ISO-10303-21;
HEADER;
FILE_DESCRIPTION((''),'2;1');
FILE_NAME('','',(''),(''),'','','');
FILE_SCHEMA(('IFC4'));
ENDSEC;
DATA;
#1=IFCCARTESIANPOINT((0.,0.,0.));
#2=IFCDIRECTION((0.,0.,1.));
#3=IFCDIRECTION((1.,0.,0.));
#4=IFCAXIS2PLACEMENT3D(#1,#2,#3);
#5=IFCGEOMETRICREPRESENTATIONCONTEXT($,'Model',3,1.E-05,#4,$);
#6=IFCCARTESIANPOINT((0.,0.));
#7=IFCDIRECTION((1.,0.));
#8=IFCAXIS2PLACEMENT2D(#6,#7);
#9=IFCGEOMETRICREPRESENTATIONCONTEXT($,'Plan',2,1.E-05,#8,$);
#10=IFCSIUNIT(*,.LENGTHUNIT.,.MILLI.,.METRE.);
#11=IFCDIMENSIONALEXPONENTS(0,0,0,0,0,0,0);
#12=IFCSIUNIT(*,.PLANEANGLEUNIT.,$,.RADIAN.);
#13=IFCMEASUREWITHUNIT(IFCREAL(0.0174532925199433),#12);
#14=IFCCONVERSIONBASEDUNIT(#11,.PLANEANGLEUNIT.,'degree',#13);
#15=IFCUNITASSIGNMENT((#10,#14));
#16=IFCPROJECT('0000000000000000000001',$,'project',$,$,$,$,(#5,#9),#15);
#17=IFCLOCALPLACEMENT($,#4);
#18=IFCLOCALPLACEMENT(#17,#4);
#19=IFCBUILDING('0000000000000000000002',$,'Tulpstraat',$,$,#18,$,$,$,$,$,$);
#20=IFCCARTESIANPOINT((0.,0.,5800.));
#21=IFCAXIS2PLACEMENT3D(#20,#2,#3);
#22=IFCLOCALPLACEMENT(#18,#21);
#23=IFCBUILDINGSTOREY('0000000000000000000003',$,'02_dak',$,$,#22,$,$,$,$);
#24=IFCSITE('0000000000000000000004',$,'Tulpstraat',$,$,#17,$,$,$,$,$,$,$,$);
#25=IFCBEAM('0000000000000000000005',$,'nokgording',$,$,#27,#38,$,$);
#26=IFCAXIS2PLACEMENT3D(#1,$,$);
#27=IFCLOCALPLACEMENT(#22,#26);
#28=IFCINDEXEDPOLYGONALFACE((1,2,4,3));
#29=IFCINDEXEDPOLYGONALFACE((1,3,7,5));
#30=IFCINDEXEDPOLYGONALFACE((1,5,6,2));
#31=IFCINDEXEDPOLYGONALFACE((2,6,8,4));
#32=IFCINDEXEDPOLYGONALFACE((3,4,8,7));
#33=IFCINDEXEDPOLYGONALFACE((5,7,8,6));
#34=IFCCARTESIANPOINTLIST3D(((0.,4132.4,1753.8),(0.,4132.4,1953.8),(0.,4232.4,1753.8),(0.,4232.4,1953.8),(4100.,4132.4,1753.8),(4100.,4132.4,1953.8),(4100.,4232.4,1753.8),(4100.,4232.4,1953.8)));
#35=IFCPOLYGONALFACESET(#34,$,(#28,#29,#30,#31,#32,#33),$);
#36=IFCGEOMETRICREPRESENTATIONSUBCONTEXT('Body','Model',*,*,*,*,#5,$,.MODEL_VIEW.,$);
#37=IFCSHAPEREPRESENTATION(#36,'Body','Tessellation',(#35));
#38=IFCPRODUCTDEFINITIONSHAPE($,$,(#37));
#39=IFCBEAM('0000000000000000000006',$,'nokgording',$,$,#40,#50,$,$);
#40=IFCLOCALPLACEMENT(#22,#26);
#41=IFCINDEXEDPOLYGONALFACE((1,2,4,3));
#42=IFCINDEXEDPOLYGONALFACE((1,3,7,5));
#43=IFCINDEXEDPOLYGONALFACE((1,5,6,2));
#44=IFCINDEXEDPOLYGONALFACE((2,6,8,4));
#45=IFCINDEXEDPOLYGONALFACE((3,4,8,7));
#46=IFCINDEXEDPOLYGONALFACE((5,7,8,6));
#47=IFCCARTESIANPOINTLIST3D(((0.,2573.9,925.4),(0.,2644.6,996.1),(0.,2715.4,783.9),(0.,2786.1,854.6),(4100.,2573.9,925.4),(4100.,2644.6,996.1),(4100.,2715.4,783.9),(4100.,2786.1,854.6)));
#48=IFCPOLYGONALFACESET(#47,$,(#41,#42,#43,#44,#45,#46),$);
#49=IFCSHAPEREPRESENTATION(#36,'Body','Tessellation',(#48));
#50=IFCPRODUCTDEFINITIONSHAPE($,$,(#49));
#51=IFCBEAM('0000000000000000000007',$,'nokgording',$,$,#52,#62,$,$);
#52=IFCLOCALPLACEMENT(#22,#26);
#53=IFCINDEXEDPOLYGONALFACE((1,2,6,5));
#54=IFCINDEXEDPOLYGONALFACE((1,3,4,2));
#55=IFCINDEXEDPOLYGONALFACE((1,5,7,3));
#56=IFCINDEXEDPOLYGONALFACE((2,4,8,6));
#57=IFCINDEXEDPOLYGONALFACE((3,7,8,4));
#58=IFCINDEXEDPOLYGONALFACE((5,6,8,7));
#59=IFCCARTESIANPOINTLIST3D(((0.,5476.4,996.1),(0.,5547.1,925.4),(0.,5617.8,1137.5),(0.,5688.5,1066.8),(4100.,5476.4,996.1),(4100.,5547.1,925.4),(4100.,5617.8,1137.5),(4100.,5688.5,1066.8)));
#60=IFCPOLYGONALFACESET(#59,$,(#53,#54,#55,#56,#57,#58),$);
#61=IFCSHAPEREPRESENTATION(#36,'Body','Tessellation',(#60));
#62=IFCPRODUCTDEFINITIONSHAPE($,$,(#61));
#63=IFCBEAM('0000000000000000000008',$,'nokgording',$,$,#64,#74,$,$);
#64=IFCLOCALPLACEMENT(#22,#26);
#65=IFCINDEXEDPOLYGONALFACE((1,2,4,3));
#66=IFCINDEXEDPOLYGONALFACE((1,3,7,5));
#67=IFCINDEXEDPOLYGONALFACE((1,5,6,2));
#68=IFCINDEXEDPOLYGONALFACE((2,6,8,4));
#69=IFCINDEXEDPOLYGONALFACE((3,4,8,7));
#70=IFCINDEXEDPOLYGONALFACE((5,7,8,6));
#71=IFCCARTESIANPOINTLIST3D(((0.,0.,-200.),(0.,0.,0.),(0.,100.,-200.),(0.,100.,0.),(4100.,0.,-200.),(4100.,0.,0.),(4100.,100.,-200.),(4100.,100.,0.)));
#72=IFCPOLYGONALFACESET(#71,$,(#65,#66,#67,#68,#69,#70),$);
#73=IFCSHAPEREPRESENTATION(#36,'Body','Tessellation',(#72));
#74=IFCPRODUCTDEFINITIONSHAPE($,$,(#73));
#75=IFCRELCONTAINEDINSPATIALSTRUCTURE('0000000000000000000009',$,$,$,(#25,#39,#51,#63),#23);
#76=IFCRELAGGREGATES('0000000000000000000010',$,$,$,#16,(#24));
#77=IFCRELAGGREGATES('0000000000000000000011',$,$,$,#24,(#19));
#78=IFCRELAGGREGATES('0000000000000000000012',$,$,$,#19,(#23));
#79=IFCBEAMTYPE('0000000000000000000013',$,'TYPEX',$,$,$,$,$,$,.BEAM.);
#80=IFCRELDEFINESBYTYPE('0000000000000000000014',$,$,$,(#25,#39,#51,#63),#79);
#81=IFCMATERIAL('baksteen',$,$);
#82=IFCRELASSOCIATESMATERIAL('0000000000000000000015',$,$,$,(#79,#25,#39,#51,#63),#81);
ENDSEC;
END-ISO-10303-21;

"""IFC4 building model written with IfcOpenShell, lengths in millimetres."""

from ifc_helpers import new_model, entity, si_unit, converted_unit, frame, origin_with_axes, origin_2d_with_axis, place, context, subcontext, project, spatial, rectangle, extrude, material, material_profile, profile_set, profile_usage, type_object, element, save


model = new_model("IFC4")

# Units and contexts
model_context = context("Model", 3, precision=1e-05, world=origin_with_axes())
plan_context = context("Plan", 2, precision=1e-05, world=origin_2d_with_axis())
body_context = subcontext(model_context, "Body", "Model", "MODEL_VIEW")
ifc_project = project(units=[si_unit("LENGTHUNIT", "METRE", prefix="MILLI"), converted_unit("PLANEANGLEUNIT", "degree", entity("IfcReal", 0.0174532925199433), si_unit("PLANEANGLEUNIT", "RADIAN"), dimensions=[0, 0, 0, 0, 0, 0, 0])], contexts=[model_context, plan_context])

# Site, building, storey
site_placement = place(None, origin_with_axes())
site = spatial("IfcSite", under=ifc_project, at=site_placement, Name="Tulpstraat")
building_placement = place(site_placement, origin_with_axes())
building = spatial("IfcBuilding", under=site, at=building_placement, Name="Tulpstraat")
storey_placement = place(building_placement, frame((0.0, 0.0, 5800.0), z_axis=(0.0, 0.0, 1.0), x_axis=(1.0, 0.0, 0.0)))
storey = spatial("IfcBuildingStorey", under=building, at=storey_placement, Name="02_dak")

# Beams
ifc_material = material(Name="baksteen")
ifc_material_profile_1 = material_profile(ifc_material, rectangle(XDim=100.0, YDim=200.0))
ifc_profile_set_1 = profile_set([ifc_material_profile_1])
ifc_profile_usage_1 = profile_usage(ifc_profile_set_1, cardinal=5)
beam_type_1 = type_object("IfcBeamType", Name="TYPEX", PredefinedType="BEAM", material=ifc_profile_set_1)
beam_1_placement = place(storey_placement, frame((0.0, 4182.4, 1853.8), z_axis=(1.0, 0.0, 0.0), x_axis=(0.0, 1.0, 0.0)))
element("IfcBeam", 1, at=beam_1_placement, inside=storey, type_object=beam_type_1, material=ifc_profile_usage_1, Name="nokgording", context=body_context, shape_type="SweptSolid", body=[
    extrude(rectangle(XDim=100.0, YDim=200.0), origin_with_axes(), (0.0, 0.0, 1.0), 4100.0),
])
ifc_profile_usage_2 = profile_usage(ifc_profile_set_1, cardinal=5)
beam_2_placement = place(storey_placement, frame((0.0, 2680.0, 890.0), z_axis=(1.0, 0.0, 0.0), x_axis=(0.0, 0.707107, 0.707107)))
element("IfcBeam", 2, at=beam_2_placement, inside=storey, type_object=beam_type_1, material=ifc_profile_usage_2, Name="nokgording", context=body_context, shape_type="SweptSolid", body=[
    extrude(rectangle(XDim=100.0, YDim=200.0), origin_with_axes(), (0.0, 0.0, 1.0), 4100.0),
])
ifc_profile_usage_3 = profile_usage(ifc_profile_set_1, cardinal=5)
beam_3_placement = place(storey_placement, frame((0.0, 5582.4, 1031.4), z_axis=(1.0, 0.0, 0.0), x_axis=(0.0, 0.707107, -0.707107)))
element("IfcBeam", 3, at=beam_3_placement, inside=storey, type_object=beam_type_1, material=ifc_profile_usage_3, Name="nokgording", context=body_context, shape_type="SweptSolid", body=[
    extrude(rectangle(XDim=100.0, YDim=200.0), origin_with_axes(), (0.0, 0.0, 1.0), 4100.0),
])
ifc_profile_usage_4 = profile_usage(ifc_profile_set_1, cardinal=5)
beam_4_placement = place(storey_placement, frame((0.0, 50.0, -100.0), z_axis=(1.0, 0.0, 0.0), x_axis=(0.0, 1.0, 0.0)))
element("IfcBeam", 4, at=beam_4_placement, inside=storey, type_object=beam_type_1, material=ifc_profile_usage_4, Name="nokgording", context=body_context, shape_type="SweptSolid", body=[
    extrude(rectangle(XDim=100.0, YDim=200.0), origin_with_axes(), (0.0, 0.0, 1.0), 4100.0),
])

save(model, "model.ifc")
